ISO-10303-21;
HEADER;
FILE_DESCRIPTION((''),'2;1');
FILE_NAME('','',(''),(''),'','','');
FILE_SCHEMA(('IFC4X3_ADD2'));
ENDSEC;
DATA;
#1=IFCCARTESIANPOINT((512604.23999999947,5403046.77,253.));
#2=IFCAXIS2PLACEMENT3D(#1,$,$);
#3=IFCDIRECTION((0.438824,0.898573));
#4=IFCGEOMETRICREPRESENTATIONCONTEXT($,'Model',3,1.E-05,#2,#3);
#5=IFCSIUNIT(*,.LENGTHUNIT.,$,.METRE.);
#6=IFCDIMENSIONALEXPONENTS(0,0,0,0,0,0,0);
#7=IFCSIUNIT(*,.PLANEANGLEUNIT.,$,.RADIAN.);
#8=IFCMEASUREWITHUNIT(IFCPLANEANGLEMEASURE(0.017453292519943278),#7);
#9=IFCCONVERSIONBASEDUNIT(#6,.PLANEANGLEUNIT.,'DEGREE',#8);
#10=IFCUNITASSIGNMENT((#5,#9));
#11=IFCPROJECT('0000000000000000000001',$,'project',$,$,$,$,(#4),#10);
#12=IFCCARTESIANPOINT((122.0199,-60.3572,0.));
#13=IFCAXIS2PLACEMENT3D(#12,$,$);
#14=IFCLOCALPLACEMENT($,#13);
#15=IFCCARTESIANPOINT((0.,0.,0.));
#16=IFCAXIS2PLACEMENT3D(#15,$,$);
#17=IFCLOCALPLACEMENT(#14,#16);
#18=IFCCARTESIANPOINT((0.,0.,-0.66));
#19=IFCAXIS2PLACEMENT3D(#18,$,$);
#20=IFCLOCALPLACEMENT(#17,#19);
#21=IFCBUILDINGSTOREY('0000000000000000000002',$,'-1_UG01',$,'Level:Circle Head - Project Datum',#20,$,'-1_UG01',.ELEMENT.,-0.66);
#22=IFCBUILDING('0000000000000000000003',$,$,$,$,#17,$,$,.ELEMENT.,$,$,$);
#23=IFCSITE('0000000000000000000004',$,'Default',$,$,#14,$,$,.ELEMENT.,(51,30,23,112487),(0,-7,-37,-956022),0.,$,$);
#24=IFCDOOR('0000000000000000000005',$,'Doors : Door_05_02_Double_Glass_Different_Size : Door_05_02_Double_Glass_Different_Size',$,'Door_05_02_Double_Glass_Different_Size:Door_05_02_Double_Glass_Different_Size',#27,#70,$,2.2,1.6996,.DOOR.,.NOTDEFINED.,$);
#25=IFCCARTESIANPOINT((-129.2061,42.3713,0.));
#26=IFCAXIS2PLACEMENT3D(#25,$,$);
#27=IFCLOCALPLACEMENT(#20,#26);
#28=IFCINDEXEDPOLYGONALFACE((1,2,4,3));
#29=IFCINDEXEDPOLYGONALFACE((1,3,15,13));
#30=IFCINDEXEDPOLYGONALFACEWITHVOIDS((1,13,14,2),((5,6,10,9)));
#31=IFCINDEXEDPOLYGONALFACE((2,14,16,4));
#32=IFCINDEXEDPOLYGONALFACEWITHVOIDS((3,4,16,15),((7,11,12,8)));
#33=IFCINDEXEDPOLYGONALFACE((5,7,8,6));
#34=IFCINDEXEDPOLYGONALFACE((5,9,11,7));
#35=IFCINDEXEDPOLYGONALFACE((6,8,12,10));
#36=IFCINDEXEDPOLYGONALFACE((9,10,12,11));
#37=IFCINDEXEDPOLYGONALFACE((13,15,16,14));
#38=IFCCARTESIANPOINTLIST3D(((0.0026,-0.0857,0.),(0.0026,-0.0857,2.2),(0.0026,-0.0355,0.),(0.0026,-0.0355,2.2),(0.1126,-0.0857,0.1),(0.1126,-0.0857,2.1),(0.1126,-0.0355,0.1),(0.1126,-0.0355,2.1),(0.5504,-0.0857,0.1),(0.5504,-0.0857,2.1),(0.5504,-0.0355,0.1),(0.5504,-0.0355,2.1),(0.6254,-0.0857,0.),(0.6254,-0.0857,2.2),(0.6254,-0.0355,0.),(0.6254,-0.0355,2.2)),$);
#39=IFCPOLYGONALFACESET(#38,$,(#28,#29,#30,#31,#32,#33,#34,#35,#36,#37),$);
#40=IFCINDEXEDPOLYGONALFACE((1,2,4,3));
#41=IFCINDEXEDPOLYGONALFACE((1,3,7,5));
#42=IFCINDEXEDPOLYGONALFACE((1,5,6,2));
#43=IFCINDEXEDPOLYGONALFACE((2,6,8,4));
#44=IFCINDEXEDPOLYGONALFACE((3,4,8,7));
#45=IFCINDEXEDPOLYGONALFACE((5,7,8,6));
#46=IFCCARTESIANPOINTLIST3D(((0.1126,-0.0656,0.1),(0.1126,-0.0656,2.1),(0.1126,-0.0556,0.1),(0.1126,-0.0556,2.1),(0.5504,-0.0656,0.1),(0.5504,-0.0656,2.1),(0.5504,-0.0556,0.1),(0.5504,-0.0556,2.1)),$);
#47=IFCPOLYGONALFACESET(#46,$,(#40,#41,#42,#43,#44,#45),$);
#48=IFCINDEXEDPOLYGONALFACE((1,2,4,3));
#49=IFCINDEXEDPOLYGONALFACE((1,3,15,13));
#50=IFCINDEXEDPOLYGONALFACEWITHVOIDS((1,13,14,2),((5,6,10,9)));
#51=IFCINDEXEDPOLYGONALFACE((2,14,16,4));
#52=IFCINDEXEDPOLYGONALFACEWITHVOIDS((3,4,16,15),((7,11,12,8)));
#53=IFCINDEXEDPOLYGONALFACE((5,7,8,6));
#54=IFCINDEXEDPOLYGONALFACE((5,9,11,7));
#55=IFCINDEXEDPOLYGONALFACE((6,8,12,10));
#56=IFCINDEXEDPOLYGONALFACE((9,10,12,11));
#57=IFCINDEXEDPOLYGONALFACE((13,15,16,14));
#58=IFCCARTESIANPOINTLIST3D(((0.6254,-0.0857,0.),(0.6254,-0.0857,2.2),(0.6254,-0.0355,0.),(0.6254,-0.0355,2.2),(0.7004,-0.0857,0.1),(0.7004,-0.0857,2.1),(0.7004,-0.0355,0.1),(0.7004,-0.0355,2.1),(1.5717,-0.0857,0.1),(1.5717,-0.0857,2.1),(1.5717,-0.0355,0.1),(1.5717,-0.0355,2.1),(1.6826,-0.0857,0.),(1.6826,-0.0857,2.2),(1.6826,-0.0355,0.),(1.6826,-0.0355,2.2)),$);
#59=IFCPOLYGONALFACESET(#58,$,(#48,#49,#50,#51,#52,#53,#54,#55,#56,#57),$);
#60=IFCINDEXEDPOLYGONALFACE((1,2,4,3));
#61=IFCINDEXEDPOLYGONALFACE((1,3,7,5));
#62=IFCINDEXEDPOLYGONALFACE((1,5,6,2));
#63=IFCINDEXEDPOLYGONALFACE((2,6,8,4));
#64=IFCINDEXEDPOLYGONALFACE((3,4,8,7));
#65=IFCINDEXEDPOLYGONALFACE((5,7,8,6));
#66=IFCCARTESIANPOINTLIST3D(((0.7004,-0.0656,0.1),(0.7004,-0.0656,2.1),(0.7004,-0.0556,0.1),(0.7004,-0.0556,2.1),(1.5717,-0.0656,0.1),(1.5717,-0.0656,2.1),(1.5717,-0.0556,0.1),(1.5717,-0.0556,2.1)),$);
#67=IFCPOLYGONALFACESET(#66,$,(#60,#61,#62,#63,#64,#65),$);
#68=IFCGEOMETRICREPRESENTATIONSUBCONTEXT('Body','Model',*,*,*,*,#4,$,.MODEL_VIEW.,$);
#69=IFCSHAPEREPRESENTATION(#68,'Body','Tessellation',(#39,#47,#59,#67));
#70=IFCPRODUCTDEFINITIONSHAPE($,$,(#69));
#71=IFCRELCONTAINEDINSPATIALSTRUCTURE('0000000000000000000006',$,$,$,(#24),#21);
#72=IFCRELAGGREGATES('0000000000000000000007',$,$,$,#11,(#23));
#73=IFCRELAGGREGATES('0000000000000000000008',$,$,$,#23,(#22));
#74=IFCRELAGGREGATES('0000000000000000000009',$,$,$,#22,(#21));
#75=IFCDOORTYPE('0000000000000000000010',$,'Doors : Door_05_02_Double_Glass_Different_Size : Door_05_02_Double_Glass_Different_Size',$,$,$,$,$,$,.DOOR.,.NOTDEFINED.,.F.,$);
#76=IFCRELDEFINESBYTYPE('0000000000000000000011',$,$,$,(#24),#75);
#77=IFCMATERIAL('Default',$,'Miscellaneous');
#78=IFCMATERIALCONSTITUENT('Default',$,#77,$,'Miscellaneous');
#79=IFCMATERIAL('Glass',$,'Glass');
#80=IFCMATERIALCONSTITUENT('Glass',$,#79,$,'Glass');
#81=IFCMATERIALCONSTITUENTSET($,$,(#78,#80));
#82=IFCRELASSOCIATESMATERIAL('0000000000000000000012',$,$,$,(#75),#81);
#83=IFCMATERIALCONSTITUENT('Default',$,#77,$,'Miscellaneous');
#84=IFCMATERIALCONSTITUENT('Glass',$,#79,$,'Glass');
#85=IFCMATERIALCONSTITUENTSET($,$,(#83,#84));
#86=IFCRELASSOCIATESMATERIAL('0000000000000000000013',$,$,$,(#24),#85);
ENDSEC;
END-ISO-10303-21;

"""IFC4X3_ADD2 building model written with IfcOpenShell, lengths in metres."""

from ifc_helpers import new_model, entity, si_unit, converted_unit, direction, frame, frame_2d, origin, origin_2d_with_axis, place, context, subcontext, project, spatial, polyline, rectangle, outline, extrude, source, transform, mapped, material, constituent, constituent_set, type_object, type_shapes, element, save


model = new_model("IFC4X3_ADD2")

# Units and contexts
model_context = context("Model", 3, precision=1e-05, world=frame((512604.23999999947, 5403046.77, 253.0)), true_north=direction((0.438824, 0.898573)))
body_context = subcontext(model_context, "Body", "Model", "MODEL_VIEW")
ifc_project = project(units=[si_unit("LENGTHUNIT", "METRE"), converted_unit("PLANEANGLEUNIT", "DEGREE", entity("IfcPlaneAngleMeasure", 0.017453292519943278), si_unit("PLANEANGLEUNIT", "RADIAN"), dimensions=[0, 0, 0, 0, 0, 0, 0])], contexts=[model_context])

# Site, building, storey
site_placement = place(None, frame((122.0199, -60.3572, 0.0)))
site = spatial("IfcSite", under=ifc_project, at=site_placement, Name="Default", CompositionType="ELEMENT", RefLatitude=(51, 30, 23, 112487), RefLongitude=(0, -7, -37, -956022), RefElevation=0.0)
building_placement = place(site_placement, origin())
building = spatial("IfcBuilding", under=site, at=building_placement, CompositionType="ELEMENT")
storey_placement = place(building_placement, frame((0.0, 0.0, -0.66)))
storey = spatial("IfcBuildingStorey", under=building, at=storey_placement, Name="-1_UG01", ObjectType="Level:Circle Head - Project Datum", LongName="-1_UG01", CompositionType="ELEMENT", Elevation=-0.66)

# Door
ifc_material_1 = material(Name="Default", Category="Miscellaneous")
ifc_constituent_1 = constituent(ifc_material_1, Name="Default", Category="Miscellaneous")
ifc_material_2 = material(Name="Glass", Category="Glass")
ifc_constituent_2 = constituent(ifc_material_2, Name="Glass", Category="Glass")
ifc_constituent_set_1 = constituent_set(constituents=[ifc_constituent_1, ifc_constituent_2])
ifc_constituent_3 = constituent(ifc_material_1, Name="Default", Category="Miscellaneous")
ifc_constituent_4 = constituent(ifc_material_2, Name="Glass", Category="Glass")
ifc_constituent_set_2 = constituent_set(constituents=[ifc_constituent_3, ifc_constituent_4])
door_type = type_object("IfcDoorType", Name="Doors : Door_05_02_Double_Glass_Different_Size : Door_05_02_Double_Glass_Different_Size", OperationType="NOTDEFINED", ParameterTakesPrecedence=False, PredefinedType="DOOR", material=ifc_constituent_set_2)
shared_shape = source(origin(), body_context, "Body", "SweptSolid", [
    extrude(outline(polyline([(-1.1, -0.3114), (1.1, -0.3114), (1.1, 0.3114), (-1.1, 0.3114), (-1.1, -0.3114)]), holes=[polyline([(1.0, 0.2014), (1.0, -0.2364), (-1.0, -0.2364), (-1.0, 0.2014), (1.0, 0.2014)])]), frame((0.314, -0.0857, 1.1), z_axis=(0.0, 1.0, 0.0), x_axis=(0.0, 0.0, -1.0)), (0.0, 0.0, 1.0), 0.0501),
    extrude(rectangle(XDim=0.4379, YDim=0.01, at=origin_2d_with_axis()), frame((0.3315, -0.0606, 0.1)), (0.0, 0.0, 1.0), 2.0),
    extrude(outline(polyline([(-0.5286, -1.1), (0.5286, -1.1), (0.5286, 1.1), (-0.5286, 1.1), (-0.5286, -1.1)]), holes=[polyline([(0.4177, 1.0), (0.4177, -1.0), (-0.4536, -1.0), (-0.4536, 1.0), (0.4177, 1.0)])]), frame((1.154, -0.0857, 1.1), z_axis=(0.0, 1.0, 0.0), x_axis=(1.0, 0.0, 0.0)), (0.0, 0.0, 1.0), 0.0501),
    extrude(rectangle(XDim=0.01, YDim=0.8713, at=frame_2d((0.0, 0.0), x_axis=(1.0, 0.0))), frame((1.1361, -0.0606, 0.1), z_axis=(0.0, 0.0, 1.0), x_axis=(0.0, 1.0, 0.0)), (0.0, 0.0, 1.0), 2.0),
])
type_shapes(door_type, [shared_shape])
door_placement = place(storey_placement, frame((-129.2061, 42.3713, 0.0)))
element("IfcDoor", 1, at=door_placement, inside=storey, type_object=door_type, material=ifc_constituent_set_1, Name="Doors : Door_05_02_Double_Glass_Different_Size : Door_05_02_Double_Glass_Different_Size", ObjectType="Door_05_02_Double_Glass_Different_Size:Door_05_02_Double_Glass_Different_Size", OperationType="NOTDEFINED", OverallHeight=2.2, OverallWidth=1.6996, PredefinedType="DOOR", context=body_context, shape_type="MappedRepresentation", body=[
    mapped(shared_shape, transform((0.0, 0.0, 0.0), scale=1.0)),
])

save(model, "model.ifc")
